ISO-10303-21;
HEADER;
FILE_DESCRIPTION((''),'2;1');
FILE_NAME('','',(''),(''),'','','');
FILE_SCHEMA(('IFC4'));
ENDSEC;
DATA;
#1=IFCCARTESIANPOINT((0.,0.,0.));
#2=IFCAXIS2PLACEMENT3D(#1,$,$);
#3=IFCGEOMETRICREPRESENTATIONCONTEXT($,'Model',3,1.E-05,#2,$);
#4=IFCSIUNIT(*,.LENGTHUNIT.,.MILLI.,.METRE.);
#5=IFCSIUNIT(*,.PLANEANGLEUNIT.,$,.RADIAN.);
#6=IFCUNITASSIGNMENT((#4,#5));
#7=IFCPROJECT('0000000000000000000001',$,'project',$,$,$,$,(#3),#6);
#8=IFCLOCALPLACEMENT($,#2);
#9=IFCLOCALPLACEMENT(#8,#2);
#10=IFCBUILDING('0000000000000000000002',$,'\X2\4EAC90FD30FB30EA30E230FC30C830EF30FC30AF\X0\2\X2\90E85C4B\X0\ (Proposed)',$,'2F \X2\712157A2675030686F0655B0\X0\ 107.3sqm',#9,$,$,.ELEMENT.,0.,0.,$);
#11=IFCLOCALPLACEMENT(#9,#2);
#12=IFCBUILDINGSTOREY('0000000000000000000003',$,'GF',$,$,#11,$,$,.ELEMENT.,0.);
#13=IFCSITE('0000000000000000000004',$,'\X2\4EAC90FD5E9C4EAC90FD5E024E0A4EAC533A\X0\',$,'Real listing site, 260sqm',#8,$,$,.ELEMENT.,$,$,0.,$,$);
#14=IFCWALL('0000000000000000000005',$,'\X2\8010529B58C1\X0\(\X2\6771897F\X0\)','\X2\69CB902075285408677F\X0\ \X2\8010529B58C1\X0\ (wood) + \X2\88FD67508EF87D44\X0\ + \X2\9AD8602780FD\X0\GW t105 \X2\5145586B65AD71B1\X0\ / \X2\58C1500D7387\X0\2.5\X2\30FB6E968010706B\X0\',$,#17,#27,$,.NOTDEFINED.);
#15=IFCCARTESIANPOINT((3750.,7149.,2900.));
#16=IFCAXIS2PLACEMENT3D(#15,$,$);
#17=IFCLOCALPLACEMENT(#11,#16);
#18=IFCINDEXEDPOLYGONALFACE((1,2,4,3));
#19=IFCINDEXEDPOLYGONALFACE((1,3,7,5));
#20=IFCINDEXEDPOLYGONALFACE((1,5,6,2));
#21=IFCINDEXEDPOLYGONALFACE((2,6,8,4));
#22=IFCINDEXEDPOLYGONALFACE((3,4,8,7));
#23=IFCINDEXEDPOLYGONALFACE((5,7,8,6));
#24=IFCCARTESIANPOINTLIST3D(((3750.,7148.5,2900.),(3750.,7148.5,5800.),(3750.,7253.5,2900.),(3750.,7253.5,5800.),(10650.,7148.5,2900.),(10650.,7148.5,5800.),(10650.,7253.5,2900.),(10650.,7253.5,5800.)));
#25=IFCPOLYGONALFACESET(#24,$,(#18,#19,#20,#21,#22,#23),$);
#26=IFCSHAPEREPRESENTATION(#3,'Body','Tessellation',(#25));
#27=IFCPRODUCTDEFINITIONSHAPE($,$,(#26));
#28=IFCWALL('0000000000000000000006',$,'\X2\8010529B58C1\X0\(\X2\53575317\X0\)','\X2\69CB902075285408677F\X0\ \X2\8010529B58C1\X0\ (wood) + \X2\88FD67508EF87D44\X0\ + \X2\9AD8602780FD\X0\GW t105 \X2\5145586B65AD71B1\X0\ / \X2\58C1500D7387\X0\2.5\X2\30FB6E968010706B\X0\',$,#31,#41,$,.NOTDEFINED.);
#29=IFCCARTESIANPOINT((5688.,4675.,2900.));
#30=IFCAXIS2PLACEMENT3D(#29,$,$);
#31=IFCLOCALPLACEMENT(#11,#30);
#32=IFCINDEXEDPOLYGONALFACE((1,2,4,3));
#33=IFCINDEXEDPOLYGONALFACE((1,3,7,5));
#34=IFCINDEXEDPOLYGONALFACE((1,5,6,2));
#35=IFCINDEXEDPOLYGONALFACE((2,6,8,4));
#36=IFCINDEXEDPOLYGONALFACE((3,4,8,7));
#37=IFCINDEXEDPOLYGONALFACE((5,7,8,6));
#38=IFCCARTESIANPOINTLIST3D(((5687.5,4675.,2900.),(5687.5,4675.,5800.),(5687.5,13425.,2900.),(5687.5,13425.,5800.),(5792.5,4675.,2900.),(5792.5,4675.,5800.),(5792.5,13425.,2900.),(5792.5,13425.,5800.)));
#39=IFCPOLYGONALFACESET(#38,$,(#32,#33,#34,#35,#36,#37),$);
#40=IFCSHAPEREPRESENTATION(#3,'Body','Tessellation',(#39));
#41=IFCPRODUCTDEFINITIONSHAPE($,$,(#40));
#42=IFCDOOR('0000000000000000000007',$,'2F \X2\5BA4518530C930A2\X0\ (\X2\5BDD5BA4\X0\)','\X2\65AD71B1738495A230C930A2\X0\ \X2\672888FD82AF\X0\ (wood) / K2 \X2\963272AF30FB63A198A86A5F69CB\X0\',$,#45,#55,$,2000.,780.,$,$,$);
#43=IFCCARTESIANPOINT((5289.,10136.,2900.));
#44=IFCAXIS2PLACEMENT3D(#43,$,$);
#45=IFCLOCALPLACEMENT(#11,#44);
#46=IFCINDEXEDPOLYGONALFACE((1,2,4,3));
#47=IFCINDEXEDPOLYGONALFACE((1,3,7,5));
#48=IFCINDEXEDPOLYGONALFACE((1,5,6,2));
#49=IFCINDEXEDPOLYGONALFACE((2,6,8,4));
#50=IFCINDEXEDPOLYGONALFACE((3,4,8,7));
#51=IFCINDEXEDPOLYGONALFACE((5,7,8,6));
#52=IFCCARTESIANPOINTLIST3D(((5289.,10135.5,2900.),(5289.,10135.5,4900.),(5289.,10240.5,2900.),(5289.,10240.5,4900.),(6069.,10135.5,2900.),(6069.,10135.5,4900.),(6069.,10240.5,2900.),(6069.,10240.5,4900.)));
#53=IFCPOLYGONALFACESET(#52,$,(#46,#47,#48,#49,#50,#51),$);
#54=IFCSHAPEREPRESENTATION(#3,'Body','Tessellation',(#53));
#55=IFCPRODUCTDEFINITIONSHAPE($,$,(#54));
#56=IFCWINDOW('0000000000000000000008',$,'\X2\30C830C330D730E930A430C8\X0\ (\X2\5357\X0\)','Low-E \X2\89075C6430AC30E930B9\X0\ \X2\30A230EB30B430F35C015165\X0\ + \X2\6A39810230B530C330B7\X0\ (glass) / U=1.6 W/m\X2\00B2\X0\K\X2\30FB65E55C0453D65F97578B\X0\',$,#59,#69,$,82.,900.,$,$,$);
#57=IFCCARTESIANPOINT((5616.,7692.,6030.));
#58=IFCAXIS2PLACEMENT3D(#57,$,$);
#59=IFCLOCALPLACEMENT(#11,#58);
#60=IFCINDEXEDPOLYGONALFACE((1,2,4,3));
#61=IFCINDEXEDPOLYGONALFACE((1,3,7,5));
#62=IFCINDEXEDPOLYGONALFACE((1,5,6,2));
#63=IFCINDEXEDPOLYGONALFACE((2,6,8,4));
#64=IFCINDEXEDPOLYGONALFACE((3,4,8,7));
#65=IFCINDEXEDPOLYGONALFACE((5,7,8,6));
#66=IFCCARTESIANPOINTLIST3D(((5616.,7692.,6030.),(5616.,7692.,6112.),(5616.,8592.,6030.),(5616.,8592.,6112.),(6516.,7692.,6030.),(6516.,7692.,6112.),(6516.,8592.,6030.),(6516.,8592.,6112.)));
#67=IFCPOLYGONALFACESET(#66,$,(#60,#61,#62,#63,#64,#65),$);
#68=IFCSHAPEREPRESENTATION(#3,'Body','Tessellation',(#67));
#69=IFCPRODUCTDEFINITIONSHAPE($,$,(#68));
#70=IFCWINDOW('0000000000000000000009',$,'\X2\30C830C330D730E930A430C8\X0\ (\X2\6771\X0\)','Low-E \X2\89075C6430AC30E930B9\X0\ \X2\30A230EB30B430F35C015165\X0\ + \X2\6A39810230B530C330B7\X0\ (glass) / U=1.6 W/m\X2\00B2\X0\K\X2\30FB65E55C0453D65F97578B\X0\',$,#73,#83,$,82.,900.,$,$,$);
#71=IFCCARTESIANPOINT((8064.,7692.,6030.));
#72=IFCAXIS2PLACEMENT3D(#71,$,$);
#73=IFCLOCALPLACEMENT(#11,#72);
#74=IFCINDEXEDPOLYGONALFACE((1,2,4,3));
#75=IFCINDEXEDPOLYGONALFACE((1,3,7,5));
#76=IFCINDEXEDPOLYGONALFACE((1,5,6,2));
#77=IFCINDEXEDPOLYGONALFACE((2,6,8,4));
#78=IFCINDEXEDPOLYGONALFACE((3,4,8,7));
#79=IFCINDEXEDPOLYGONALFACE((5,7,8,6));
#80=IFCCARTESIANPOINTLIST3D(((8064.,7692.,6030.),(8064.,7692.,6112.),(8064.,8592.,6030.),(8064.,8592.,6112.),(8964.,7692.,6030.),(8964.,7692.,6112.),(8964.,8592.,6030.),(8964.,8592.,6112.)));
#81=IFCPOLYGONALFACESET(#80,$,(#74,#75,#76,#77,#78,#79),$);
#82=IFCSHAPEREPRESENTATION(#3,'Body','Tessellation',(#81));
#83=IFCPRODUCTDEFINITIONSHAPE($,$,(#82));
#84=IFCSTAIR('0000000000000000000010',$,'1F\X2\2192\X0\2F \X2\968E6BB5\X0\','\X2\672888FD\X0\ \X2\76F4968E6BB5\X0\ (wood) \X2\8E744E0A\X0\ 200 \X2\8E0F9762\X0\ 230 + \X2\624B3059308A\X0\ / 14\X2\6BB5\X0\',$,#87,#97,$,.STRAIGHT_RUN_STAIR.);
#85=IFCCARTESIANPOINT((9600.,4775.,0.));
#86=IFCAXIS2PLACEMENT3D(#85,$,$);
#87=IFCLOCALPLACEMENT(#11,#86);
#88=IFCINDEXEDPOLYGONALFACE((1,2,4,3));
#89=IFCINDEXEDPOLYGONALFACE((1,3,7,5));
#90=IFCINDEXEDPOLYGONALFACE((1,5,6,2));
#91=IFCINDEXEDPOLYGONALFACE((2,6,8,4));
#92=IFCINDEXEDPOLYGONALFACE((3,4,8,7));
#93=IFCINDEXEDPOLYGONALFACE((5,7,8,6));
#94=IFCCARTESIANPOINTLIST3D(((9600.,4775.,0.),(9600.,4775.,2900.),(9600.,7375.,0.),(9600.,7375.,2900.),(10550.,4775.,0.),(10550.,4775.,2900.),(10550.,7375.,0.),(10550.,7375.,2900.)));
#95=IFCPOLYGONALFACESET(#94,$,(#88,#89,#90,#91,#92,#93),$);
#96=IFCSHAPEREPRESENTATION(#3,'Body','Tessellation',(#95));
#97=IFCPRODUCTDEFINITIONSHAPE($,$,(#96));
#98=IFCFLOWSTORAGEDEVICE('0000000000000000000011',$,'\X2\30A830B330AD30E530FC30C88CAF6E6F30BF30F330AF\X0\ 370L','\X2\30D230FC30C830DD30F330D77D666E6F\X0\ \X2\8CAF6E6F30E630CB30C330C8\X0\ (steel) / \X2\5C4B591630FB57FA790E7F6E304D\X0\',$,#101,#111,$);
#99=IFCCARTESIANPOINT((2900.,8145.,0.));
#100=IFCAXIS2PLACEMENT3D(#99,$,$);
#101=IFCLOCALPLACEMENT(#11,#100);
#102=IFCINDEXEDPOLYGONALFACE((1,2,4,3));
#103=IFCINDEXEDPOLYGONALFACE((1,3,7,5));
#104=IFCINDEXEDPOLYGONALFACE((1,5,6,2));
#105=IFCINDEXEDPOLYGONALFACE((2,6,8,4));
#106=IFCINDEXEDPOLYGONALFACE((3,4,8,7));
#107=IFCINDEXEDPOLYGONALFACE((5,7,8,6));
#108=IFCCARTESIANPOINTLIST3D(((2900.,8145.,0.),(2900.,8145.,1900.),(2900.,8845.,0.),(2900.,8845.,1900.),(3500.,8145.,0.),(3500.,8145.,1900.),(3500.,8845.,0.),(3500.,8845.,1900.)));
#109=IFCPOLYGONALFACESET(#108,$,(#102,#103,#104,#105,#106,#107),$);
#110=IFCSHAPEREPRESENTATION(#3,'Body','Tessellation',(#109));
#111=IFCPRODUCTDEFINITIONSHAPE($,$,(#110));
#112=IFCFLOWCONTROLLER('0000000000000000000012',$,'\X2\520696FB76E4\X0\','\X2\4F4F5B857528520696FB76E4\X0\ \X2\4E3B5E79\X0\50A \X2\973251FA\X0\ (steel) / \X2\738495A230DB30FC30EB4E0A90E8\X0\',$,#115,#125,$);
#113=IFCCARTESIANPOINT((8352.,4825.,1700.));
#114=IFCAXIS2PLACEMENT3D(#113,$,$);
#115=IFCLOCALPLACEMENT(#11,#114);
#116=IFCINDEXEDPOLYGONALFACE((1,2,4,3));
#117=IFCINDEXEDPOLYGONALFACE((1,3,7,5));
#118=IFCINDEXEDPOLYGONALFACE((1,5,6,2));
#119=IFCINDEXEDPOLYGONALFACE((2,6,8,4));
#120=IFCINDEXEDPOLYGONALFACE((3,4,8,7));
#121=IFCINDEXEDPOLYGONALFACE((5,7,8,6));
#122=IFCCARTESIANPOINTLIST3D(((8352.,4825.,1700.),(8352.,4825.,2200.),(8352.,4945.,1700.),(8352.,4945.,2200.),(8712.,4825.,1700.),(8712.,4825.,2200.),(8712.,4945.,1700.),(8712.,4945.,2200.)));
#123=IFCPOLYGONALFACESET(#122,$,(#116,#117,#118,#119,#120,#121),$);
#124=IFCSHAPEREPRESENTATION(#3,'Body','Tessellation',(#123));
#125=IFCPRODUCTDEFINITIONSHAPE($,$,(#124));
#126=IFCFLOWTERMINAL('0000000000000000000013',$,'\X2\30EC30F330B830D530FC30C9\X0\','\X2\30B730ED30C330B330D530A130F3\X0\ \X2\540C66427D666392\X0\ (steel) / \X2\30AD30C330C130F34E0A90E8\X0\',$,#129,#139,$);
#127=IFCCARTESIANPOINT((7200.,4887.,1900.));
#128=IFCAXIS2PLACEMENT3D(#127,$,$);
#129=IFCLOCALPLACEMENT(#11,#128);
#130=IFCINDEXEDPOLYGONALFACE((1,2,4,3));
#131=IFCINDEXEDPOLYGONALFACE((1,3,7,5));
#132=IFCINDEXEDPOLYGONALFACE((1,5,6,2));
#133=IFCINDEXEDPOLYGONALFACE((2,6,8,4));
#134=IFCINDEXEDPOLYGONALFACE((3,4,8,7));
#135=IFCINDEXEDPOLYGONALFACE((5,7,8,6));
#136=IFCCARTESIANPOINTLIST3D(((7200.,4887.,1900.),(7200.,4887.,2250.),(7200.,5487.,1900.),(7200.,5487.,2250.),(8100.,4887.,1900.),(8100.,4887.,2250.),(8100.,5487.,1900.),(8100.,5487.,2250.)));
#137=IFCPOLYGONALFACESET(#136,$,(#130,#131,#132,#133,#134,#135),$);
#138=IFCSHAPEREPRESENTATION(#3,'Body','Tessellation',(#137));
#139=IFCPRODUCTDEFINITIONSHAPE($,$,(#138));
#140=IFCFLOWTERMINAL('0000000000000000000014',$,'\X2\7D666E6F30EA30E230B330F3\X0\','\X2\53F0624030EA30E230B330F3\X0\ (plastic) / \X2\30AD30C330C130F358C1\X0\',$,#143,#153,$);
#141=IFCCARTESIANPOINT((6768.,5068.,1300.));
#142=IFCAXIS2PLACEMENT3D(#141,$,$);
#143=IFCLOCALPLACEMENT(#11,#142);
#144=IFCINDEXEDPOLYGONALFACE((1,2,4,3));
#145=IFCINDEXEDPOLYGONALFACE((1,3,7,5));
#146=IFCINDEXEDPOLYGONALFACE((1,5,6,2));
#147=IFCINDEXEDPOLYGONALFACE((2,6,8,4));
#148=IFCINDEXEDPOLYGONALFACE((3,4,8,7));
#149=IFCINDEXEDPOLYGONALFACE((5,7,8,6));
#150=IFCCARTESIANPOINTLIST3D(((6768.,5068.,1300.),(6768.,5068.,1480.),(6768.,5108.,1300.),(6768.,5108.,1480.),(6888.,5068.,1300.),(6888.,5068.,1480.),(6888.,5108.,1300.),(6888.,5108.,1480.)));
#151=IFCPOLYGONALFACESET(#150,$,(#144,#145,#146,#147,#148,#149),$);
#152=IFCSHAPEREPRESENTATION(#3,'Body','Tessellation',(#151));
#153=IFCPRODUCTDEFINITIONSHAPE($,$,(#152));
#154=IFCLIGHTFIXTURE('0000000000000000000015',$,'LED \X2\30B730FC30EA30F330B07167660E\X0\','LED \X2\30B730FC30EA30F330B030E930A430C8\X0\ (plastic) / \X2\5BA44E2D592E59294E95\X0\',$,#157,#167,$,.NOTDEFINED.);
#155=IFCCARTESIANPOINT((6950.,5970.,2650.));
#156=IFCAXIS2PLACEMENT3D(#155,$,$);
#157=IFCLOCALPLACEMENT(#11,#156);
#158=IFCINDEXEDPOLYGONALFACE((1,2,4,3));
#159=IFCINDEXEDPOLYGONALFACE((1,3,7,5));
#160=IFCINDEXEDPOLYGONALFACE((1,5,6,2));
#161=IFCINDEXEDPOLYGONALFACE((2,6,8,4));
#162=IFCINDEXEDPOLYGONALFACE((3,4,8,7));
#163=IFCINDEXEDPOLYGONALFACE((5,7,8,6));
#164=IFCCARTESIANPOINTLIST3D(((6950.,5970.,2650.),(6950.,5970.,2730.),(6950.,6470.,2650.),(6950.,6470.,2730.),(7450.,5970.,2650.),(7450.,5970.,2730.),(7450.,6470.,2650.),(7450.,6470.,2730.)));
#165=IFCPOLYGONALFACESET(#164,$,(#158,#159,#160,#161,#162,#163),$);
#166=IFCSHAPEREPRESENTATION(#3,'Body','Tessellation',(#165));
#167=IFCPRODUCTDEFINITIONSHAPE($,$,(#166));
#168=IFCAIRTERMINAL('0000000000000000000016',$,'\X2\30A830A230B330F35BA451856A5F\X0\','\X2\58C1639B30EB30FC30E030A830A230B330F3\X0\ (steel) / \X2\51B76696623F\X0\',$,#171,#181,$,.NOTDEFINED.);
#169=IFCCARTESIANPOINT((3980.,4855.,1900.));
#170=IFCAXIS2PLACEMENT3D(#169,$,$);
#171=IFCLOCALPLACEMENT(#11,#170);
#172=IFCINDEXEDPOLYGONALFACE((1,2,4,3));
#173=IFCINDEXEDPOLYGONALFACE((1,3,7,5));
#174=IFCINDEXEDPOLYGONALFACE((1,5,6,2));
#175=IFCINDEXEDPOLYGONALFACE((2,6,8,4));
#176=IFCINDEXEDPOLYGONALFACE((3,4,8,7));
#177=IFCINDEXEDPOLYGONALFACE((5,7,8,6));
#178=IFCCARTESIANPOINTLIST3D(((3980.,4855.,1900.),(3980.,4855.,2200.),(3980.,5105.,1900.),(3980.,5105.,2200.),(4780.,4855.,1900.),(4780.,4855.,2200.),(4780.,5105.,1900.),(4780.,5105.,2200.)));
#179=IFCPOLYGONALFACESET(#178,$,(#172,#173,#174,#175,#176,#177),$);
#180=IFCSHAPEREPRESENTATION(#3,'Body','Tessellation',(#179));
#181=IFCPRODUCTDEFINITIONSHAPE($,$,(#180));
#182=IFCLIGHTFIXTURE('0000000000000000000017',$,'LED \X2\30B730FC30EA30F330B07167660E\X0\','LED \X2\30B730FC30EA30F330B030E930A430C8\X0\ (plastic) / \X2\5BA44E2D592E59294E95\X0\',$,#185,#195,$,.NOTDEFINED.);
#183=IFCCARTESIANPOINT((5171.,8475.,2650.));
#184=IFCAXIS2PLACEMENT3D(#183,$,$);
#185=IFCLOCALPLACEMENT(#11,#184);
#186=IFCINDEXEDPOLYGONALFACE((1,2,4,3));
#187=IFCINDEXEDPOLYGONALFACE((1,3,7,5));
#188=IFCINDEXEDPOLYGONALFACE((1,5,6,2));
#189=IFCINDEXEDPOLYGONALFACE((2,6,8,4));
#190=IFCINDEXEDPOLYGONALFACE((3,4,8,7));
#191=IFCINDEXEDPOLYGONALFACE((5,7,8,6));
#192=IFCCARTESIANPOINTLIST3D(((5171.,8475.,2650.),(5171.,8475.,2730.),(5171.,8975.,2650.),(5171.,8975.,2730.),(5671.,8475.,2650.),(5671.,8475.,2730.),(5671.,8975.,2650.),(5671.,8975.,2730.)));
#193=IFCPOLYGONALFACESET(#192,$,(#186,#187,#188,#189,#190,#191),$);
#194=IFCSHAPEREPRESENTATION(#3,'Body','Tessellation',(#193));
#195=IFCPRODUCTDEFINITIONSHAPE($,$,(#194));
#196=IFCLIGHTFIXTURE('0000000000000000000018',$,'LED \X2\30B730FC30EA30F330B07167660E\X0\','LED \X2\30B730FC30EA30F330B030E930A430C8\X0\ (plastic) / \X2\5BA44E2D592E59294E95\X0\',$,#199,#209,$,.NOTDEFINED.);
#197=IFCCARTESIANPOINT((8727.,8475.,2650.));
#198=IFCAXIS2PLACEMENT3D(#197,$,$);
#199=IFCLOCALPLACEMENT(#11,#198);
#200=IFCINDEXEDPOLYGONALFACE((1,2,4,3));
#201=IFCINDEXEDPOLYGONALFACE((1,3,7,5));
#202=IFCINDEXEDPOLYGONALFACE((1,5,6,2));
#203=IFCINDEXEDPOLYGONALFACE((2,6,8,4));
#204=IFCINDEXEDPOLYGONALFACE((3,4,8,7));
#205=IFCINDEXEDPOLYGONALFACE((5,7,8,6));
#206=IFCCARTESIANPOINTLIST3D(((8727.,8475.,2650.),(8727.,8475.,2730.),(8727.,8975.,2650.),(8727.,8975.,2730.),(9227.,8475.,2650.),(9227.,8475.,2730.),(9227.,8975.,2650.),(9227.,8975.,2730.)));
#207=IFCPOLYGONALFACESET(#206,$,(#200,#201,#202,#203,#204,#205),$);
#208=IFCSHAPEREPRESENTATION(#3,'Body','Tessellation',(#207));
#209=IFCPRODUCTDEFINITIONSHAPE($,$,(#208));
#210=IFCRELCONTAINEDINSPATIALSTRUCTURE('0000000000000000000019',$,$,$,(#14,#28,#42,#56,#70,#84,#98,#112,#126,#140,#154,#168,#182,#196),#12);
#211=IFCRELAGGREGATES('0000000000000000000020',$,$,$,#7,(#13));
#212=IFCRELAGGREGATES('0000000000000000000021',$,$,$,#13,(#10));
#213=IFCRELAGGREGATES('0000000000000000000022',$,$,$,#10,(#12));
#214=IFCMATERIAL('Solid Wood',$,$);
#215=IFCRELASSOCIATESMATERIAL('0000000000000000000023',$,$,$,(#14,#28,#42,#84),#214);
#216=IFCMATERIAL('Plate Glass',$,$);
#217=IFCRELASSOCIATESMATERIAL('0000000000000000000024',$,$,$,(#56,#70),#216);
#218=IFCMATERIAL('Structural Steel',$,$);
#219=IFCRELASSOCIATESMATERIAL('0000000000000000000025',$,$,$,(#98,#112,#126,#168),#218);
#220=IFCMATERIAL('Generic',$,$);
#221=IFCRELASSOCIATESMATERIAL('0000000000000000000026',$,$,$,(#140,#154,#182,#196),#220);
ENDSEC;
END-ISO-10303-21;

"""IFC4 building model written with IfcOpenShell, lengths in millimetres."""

from ifc_helpers import new_model, si_unit, frame, frame_2d, origin, place, context, project, spatial, rectangle, extrude, material, element, fill, save


model = new_model("IFC4")

# Units and contexts
model_context = context("Model", 3, precision=1e-05, world=origin())
ifc_project = project(units=[si_unit("LENGTHUNIT", "METRE", prefix="MILLI"), si_unit("PLANEANGLEUNIT", "RADIAN")], contexts=[model_context])

# Site, building, storey
site_placement = place(None, origin())
site = spatial("IfcSite", under=ifc_project, at=site_placement, Name="京都府京都市上京区", ObjectType="Real listing site, 260sqm", CompositionType="ELEMENT", RefElevation=0.0)
building_placement = place(site_placement, origin())
building = spatial("IfcBuilding", under=site, at=building_placement, Name="京都・リモートワーク2部屋 (Proposed)", ObjectType="2F 無垢材と漆喰 107.3sqm", CompositionType="ELEMENT", ElevationOfRefHeight=0.0, ElevationOfTerrain=0.0)
storey_placement = place(building_placement, origin())
storey = spatial("IfcBuildingStorey", under=building, at=storey_placement, Name="GF", CompositionType="ELEMENT", Elevation=0.0)

# Shared definitions
ifc_material_1 = material(Name="Solid Wood")

# Wall
wall_1_placement = place(storey_placement, frame((3750.0, 7149.0, 2900.0)))
element("IfcWall", 1, at=wall_1_placement, inside=storey, material=ifc_material_1, Name="耐力壁(東西)", Description="構造用合板 耐力壁 (wood) + 製材軸組 + 高性能GW t105 充填断熱 / 壁倍率2.5・準耐火", PredefinedType="NOTDEFINED", context=model_context, shape_type="SweptSolid", body=[
    extrude(rectangle(XDim=6900.0, YDim=105.0, at=frame_2d((3450.0, 52.0))), frame((3750.0, 7149.0, 2900.0)), (0.0, 0.0, 1.0), 2900.0),
])

# Wall, opening, door
wall_2_placement = place(storey_placement, frame((5688.0, 4675.0, 2900.0)))
wall_2 = element("IfcWall", 2, at=wall_2_placement, inside=storey, material=ifc_material_1, Name="耐力壁(南北)", Description="構造用合板 耐力壁 (wood) + 製材軸組 + 高性能GW t105 充填断熱 / 壁倍率2.5・準耐火", PredefinedType="NOTDEFINED", context=model_context, shape_type="SweptSolid", body=[
    extrude(rectangle(XDim=105.0, YDim=8750.0, at=frame_2d((52.0, 4375.0))), frame((5688.0, 4675.0, 2900.0)), (0.0, 0.0, 1.0), 2900.0),
])
opening_placement = place(storey_placement, frame((5289.0, 10136.0, 2900.0)))
opening = element("IfcOpeningElement", 3, at=opening_placement, cuts=wall_2, PredefinedType="NOTDEFINED", context=model_context, shape_type="SweptSolid", body=[
    extrude(rectangle(XDim=780.0, YDim=105.0, at=frame_2d((390.0, 52.0))), frame((5289.0, 10136.0, 2900.0)), (0.0, 0.0, 1.0), 2000.0),
])
door_placement = place(storey_placement, frame((5289.0, 10136.0, 2900.0)))
door = element("IfcDoor", 4, at=door_placement, inside=storey, material=ifc_material_1, Name="2F 室内ドア (寝室)", Description="断熱玄関ドア 木製芯 (wood) / K2 防犯・採風機構", OverallHeight=2000.0, OverallWidth=780.0, context=model_context, shape_type="SweptSolid", body=[
    extrude(rectangle(XDim=780.0, YDim=105.0, at=frame_2d((390.0, 52.0))), frame((5289.0, 10136.0, 2900.0)), (0.0, 0.0, 1.0), 2000.0),
])
fill(opening, door)

# Windows
ifc_material_2 = material(Name="Plate Glass")
window_1_placement = place(storey_placement, frame((5616.0, 7692.0, 6030.0)))
element("IfcWindow", 5, at=window_1_placement, inside=storey, material=ifc_material_2, Name="トップライト (南)", Description="Low-E 複層ガラス アルゴン封入 + 樹脂サッシ (glass) / U=1.6 W/m²K・日射取得型", OverallHeight=82.0, OverallWidth=900.0, context=model_context, shape_type="SweptSolid", body=[
    extrude(rectangle(XDim=900.0, YDim=900.0, at=frame_2d((450.0, 450.0))), frame((5616.0, 7692.0, 6030.0)), (0.0, 0.0, 1.0), 82.0),
])
window_2_placement = place(storey_placement, frame((8064.0, 7692.0, 6030.0)))
element("IfcWindow", 6, at=window_2_placement, inside=storey, material=ifc_material_2, Name="トップライト (東)", Description="Low-E 複層ガラス アルゴン封入 + 樹脂サッシ (glass) / U=1.6 W/m²K・日射取得型", OverallHeight=82.0, OverallWidth=900.0, context=model_context, shape_type="SweptSolid", body=[
    extrude(rectangle(XDim=900.0, YDim=900.0, at=frame_2d((450.0, 450.0))), frame((8064.0, 7692.0, 6030.0)), (0.0, 0.0, 1.0), 82.0),
])

# Stair
stair_placement = place(storey_placement, frame((9600.0, 4775.0, 0.0)))
element("IfcStair", 7, at=stair_placement, inside=storey, material=ifc_material_1, Name="1F→2F 階段", Description="木製 直階段 (wood) 蹴上 200 踏面 230 + 手すり / 14段", PredefinedType="STRAIGHT_RUN_STAIR", context=model_context, shape_type="SweptSolid", body=[
    extrude(rectangle(XDim=950.0, YDim=2600.0, at=frame_2d((475.0, 1300.0))), frame((9600.0, 4775.0, 0.0)), (0.0, 0.0, 1.0), 2900.0),
])

# Flow storage device
ifc_material_3 = material(Name="Structural Steel")
flow_storage_device_placement = place(storey_placement, frame((2900.0, 8145.0, 0.0)))
element("IfcFlowStorageDevice", 8, at=flow_storage_device_placement, inside=storey, material=ifc_material_3, Name="エコキュート貯湯タンク 370L", Description="ヒートポンプ給湯 貯湯ユニット (steel) / 屋外・基礎置き", context=model_context, shape_type="SweptSolid", body=[
    extrude(rectangle(XDim=600.0, YDim=700.0, at=frame_2d((300.0, 350.0))), frame((2900.0, 8145.0, 0.0)), (0.0, 0.0, 1.0), 1900.0),
])

# Flow controller
flow_controller_placement = place(storey_placement, frame((8352.0, 4825.0, 1700.0)))
element("IfcFlowController", 9, at=flow_controller_placement, inside=storey, material=ifc_material_3, Name="分電盤", Description="住宅用分電盤 主幹50A 露出 (steel) / 玄関ホール上部", context=model_context, shape_type="SweptSolid", body=[
    extrude(rectangle(XDim=360.0, YDim=120.0, at=frame_2d((180.0, 60.0))), frame((8352.0, 4825.0, 1700.0)), (0.0, 0.0, 1.0), 500.0),
])

# Flow terminals
flow_terminal_1_placement = place(storey_placement, frame((7200.0, 4887.0, 1900.0)))
element("IfcFlowTerminal", 10, at=flow_terminal_1_placement, inside=storey, material=ifc_material_3, Name="レンジフード", Description="シロッコファン 同時給排 (steel) / キッチン上部", context=model_context, shape_type="SweptSolid", body=[
    extrude(rectangle(XDim=900.0, YDim=600.0, at=frame_2d((450.0, 300.0))), frame((7200.0, 4887.0, 1900.0)), (0.0, 0.0, 1.0), 350.0),
])
ifc_material_4 = material(Name="Generic")
flow_terminal_2_placement = place(storey_placement, frame((6768.0, 5068.0, 1300.0)))
element("IfcFlowTerminal", 11, at=flow_terminal_2_placement, inside=storey, material=ifc_material_4, Name="給湯リモコン", Description="台所リモコン (plastic) / キッチン壁", context=model_context, shape_type="SweptSolid", body=[
    extrude(rectangle(XDim=120.0, YDim=40.0, at=frame_2d((60.0, 20.0))), frame((6768.0, 5068.0, 1300.0)), (0.0, 0.0, 1.0), 180.0),
])

# Light fixture
light_fixture_1_placement = place(storey_placement, frame((6950.0, 5970.0, 2650.0)))
element("IfcLightFixture", 12, at=light_fixture_1_placement, inside=storey, material=ifc_material_4, Name="LED シーリング照明", Description="LED シーリングライト (plastic) / 室中央天井", PredefinedType="NOTDEFINED", context=model_context, shape_type="SweptSolid", body=[
    extrude(rectangle(XDim=500.0, YDim=500.0, at=frame_2d((250.0, 250.0))), frame((6950.0, 5970.0, 2650.0)), (0.0, 0.0, 1.0), 80.0),
])

# Air terminal
air_terminal_1_placement = place(storey_placement, frame((3980.0, 4855.0, 1900.0)))
element("IfcAirTerminal", 13, at=air_terminal_1_placement, inside=storey, material=ifc_material_3, Name="エアコン室内機", Description="壁掛ルームエアコン (steel) / 冷暖房", PredefinedType="NOTDEFINED", context=model_context, shape_type="SweptSolid", body=[
    extrude(rectangle(XDim=800.0, YDim=250.0, at=frame_2d((400.0, 125.0))), frame((3980.0, 4855.0, 1900.0)), (0.0, 0.0, 1.0), 300.0),
])

# Light fixtures
light_fixture_2_placement = place(storey_placement, frame((5171.0, 8475.0, 2650.0)))
element("IfcLightFixture", 14, at=light_fixture_2_placement, inside=storey, material=ifc_material_4, Name="LED シーリング照明", Description="LED シーリングライト (plastic) / 室中央天井", PredefinedType="NOTDEFINED", context=model_context, shape_type="SweptSolid", body=[
    extrude(rectangle(XDim=500.0, YDim=500.0, at=frame_2d((250.0, 250.0))), frame((5171.0, 8475.0, 2650.0)), (0.0, 0.0, 1.0), 80.0),
])
light_fixture_3_placement = place(storey_placement, frame((8727.0, 8475.0, 2650.0)))
element("IfcLightFixture", 15, at=light_fixture_3_placement, inside=storey, material=ifc_material_4, Name="LED シーリング照明", Description="LED シーリングライト (plastic) / 室中央天井", PredefinedType="NOTDEFINED", context=model_context, shape_type="SweptSolid", body=[
    extrude(rectangle(XDim=500.0, YDim=500.0, at=frame_2d((250.0, 250.0))), frame((8727.0, 8475.0, 2650.0)), (0.0, 0.0, 1.0), 80.0),
])

save(model, "model.ifc")
